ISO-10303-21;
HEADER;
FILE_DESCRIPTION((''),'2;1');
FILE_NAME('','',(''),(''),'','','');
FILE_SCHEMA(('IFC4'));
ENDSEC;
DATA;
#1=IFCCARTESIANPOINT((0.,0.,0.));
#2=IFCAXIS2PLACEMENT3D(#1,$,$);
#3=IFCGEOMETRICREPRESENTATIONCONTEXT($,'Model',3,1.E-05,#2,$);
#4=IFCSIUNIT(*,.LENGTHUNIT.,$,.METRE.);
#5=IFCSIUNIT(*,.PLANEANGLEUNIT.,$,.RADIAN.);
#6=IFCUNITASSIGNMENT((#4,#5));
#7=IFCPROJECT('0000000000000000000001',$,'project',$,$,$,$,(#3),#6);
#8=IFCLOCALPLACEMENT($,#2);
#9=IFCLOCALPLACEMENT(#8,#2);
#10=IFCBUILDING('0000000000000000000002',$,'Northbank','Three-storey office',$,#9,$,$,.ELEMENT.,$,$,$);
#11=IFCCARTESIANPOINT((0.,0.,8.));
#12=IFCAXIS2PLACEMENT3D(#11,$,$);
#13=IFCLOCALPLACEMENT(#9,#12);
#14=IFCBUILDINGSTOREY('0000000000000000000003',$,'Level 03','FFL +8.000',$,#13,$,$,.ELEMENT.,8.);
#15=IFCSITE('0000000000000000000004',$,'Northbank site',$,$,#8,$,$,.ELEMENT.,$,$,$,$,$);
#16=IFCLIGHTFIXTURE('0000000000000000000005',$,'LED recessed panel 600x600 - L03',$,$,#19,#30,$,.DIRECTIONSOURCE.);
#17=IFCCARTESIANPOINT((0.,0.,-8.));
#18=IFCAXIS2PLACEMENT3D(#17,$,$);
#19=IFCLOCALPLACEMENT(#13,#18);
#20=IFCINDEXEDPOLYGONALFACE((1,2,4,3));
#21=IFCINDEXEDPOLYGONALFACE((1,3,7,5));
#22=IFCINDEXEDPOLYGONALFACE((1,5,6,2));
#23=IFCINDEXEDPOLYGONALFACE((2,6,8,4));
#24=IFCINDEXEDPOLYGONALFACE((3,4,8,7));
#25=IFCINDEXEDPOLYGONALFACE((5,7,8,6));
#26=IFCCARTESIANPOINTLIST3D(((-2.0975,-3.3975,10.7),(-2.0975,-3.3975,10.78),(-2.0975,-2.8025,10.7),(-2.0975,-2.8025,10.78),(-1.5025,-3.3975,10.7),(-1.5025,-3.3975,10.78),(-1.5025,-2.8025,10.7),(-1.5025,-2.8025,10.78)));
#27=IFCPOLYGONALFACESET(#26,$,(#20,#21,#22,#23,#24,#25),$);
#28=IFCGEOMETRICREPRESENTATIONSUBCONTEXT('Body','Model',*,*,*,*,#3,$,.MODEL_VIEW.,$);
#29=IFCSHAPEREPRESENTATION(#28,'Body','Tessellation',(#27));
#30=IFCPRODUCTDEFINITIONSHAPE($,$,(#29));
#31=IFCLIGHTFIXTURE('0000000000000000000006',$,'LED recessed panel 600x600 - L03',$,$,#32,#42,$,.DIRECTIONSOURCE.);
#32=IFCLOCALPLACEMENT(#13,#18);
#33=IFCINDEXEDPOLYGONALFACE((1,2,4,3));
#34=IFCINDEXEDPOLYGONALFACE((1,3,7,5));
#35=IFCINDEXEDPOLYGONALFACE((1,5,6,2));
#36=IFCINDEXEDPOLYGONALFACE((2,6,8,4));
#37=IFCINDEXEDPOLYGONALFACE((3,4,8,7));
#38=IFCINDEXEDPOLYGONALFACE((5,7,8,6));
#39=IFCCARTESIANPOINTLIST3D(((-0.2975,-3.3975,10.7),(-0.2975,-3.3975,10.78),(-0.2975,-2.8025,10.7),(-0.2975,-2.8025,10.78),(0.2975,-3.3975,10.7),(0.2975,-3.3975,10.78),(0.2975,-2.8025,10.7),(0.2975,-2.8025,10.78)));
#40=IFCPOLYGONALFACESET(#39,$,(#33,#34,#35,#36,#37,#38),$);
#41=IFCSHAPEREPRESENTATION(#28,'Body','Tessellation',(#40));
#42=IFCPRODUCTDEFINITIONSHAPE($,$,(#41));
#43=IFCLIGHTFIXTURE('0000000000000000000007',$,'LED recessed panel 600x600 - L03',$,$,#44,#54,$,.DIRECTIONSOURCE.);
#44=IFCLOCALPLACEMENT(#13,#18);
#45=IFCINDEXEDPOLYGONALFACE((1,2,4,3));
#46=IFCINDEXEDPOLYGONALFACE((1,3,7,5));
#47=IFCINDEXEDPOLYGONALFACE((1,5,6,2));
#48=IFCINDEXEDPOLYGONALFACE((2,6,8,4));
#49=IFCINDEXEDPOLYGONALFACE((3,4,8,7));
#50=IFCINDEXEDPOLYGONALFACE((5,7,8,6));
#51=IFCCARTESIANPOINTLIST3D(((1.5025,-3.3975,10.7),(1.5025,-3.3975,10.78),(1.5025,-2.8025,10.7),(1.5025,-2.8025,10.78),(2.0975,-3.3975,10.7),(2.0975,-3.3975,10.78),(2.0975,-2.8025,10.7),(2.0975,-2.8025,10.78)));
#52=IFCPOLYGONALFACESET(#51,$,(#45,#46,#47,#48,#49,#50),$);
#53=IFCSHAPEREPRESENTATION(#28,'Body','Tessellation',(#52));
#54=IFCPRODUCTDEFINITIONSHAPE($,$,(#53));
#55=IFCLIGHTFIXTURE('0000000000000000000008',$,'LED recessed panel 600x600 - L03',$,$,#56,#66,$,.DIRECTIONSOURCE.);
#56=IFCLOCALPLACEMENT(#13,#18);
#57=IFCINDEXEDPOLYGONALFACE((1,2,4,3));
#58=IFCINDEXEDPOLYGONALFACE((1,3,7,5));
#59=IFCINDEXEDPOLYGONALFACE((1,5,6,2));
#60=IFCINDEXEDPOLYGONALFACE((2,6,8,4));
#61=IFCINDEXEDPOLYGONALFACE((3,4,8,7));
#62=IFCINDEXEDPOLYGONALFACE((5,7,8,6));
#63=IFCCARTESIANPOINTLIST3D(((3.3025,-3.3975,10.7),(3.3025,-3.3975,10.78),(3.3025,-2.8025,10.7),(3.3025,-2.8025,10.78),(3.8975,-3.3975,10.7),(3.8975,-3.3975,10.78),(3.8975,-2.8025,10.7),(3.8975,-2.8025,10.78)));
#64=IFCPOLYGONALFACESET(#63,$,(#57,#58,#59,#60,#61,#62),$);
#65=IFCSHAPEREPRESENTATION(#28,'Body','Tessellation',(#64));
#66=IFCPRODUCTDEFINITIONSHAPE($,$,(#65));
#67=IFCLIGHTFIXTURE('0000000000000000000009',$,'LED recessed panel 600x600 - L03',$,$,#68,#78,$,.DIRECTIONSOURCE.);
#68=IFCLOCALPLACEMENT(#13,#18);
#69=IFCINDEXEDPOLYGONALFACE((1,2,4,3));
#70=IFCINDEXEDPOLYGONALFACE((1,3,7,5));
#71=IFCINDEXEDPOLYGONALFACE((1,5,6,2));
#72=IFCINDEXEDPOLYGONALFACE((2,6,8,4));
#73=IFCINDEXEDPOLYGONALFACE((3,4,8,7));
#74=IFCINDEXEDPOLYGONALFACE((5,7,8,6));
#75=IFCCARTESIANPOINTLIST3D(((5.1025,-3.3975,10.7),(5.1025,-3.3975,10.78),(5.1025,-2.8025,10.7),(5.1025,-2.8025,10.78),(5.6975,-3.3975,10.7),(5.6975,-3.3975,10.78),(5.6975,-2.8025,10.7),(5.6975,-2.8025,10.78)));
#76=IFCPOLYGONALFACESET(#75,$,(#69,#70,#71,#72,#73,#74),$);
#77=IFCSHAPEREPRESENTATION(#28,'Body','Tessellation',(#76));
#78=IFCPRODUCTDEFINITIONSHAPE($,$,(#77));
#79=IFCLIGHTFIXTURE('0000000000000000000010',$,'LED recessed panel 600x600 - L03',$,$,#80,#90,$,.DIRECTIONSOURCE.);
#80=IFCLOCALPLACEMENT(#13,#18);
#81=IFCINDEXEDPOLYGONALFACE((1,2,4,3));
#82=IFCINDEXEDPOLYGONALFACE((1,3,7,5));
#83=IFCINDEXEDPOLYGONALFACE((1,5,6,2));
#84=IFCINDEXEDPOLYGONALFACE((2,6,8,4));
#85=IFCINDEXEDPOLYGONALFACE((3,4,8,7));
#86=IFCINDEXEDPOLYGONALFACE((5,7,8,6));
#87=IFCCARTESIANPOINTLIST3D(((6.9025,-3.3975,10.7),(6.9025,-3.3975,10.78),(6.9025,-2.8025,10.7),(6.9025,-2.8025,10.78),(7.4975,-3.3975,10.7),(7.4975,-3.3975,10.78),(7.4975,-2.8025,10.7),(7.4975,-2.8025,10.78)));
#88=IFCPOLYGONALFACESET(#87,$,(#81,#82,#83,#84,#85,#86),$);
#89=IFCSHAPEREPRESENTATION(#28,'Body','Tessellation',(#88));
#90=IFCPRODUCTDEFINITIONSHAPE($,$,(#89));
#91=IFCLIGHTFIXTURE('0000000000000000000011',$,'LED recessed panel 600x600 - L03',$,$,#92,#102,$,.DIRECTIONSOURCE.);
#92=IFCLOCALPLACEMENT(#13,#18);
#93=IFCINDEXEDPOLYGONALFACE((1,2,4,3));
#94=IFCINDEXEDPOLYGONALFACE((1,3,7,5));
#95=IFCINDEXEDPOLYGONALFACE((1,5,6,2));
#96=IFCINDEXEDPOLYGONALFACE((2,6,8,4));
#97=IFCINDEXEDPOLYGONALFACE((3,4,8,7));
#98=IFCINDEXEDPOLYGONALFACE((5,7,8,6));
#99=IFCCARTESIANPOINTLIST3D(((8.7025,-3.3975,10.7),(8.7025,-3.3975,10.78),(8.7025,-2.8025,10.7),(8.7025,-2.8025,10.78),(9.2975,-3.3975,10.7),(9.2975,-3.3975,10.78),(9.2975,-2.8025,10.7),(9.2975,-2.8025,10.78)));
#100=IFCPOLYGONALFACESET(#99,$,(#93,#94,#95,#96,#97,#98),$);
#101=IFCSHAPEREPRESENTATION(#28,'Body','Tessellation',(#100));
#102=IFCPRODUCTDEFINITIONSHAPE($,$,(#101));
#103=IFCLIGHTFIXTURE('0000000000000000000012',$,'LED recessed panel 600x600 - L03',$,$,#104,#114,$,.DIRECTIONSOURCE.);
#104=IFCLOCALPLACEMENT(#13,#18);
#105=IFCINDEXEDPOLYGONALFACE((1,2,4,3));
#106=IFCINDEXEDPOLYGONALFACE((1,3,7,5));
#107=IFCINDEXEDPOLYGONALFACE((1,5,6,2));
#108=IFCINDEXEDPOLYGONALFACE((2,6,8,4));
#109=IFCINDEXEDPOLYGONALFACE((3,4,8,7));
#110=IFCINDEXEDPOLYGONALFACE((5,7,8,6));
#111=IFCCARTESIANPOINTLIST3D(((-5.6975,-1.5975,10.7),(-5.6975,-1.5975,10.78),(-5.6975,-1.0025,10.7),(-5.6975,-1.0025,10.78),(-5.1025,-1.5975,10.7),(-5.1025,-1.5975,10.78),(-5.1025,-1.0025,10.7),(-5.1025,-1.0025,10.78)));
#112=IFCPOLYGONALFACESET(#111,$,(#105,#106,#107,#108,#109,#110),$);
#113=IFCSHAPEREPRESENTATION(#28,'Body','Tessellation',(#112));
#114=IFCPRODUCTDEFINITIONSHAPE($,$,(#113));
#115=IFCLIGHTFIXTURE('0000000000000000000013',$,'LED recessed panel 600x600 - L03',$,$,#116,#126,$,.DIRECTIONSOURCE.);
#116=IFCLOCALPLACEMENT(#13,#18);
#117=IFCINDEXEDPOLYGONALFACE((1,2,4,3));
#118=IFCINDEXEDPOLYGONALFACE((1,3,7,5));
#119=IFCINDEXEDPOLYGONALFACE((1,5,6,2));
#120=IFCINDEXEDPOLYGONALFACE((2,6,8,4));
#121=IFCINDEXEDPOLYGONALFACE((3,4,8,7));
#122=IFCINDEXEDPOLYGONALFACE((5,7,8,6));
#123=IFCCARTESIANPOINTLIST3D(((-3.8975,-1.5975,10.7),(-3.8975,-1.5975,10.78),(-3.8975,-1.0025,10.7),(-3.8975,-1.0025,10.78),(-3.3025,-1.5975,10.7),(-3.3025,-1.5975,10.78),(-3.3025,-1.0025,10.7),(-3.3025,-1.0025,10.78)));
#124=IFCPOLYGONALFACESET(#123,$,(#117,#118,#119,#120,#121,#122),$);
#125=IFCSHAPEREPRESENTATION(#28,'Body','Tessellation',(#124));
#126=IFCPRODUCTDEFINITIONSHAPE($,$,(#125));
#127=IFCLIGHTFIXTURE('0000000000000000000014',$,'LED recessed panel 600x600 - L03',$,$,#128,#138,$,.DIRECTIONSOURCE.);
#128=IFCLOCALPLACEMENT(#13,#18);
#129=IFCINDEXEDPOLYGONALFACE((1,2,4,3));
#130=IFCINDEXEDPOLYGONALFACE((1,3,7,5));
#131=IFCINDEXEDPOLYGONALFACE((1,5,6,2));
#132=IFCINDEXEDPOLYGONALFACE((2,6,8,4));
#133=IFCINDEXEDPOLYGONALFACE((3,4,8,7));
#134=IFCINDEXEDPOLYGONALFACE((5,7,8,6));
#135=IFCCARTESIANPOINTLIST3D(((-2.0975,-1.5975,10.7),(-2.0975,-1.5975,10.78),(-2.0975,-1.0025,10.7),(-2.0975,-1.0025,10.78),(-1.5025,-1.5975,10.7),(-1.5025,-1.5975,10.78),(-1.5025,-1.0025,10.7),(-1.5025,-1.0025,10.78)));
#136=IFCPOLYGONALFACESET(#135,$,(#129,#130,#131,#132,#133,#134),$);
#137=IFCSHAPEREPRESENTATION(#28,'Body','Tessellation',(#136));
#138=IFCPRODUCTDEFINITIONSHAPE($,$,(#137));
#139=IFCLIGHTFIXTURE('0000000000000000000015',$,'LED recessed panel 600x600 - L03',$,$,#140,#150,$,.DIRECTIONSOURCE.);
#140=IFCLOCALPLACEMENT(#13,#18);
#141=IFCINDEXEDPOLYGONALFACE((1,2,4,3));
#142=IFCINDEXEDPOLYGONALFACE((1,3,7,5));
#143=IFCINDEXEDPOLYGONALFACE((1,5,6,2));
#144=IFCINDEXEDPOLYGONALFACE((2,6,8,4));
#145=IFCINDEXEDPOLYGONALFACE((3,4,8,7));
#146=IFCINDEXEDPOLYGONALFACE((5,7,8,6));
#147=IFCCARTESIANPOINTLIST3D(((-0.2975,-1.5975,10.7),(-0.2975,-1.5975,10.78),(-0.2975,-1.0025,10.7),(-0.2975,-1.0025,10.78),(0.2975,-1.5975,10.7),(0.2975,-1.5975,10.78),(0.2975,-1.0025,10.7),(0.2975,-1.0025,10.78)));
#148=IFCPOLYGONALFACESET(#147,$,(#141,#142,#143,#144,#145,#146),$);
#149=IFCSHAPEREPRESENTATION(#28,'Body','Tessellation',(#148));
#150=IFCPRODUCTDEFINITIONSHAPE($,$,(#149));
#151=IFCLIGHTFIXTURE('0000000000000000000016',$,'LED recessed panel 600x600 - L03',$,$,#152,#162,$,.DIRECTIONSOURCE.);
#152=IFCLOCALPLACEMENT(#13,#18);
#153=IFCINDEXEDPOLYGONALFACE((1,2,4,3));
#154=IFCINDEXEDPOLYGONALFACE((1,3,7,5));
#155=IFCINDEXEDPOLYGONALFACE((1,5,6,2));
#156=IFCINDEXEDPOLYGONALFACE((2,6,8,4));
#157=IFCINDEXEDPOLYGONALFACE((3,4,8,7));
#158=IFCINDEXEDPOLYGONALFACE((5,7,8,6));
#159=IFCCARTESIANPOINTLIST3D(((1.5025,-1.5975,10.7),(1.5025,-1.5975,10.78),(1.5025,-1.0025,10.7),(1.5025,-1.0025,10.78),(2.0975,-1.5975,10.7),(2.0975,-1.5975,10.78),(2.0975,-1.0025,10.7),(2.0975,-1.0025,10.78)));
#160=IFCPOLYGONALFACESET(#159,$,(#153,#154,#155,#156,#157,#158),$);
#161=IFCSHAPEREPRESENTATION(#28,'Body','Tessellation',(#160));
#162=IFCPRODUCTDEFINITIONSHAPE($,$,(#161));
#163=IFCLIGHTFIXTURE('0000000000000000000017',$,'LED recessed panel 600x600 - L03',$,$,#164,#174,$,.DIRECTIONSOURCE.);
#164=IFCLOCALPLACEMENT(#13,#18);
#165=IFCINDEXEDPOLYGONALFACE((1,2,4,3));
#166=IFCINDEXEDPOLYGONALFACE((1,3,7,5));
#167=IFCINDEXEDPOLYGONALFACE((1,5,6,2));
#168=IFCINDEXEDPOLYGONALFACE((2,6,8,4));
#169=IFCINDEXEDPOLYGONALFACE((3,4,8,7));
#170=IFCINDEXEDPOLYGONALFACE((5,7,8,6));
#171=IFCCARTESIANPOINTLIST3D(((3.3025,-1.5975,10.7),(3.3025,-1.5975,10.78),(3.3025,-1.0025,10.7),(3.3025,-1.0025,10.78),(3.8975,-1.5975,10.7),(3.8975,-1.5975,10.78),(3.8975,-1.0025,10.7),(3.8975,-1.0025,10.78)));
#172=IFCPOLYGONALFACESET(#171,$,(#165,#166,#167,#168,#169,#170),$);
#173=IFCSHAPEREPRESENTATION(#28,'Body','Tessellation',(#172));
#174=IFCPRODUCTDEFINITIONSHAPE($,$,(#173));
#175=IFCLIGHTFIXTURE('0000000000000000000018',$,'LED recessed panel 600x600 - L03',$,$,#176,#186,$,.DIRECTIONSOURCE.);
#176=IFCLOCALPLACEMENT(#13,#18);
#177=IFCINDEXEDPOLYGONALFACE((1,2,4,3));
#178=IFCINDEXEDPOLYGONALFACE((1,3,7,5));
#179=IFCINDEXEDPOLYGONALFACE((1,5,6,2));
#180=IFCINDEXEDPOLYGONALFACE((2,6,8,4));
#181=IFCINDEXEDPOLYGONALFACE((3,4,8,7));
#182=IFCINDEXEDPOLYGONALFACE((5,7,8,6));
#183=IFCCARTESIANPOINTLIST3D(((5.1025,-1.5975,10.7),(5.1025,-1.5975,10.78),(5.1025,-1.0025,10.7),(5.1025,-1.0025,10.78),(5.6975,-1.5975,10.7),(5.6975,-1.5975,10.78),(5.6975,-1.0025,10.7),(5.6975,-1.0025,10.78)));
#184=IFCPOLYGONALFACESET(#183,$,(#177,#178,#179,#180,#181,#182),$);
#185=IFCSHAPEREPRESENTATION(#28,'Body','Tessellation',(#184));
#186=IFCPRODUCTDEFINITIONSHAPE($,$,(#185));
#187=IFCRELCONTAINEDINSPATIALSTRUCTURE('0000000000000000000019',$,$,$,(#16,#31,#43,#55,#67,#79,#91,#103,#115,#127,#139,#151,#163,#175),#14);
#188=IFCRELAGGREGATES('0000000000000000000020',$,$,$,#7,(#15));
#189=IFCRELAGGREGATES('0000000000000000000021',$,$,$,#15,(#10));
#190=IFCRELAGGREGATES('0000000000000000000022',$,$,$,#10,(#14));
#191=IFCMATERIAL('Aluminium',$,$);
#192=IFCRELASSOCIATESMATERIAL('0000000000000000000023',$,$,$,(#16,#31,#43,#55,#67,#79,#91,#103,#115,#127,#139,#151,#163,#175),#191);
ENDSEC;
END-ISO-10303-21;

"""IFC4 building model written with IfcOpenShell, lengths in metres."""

from ifc_helpers import new_model, si_unit, frame, origin, place, context, subcontext, project, spatial, rectangle, extrude, material, element, save


model = new_model("IFC4")

# Units and contexts
model_context = context("Model", 3, precision=1e-05, world=origin())
body_context = subcontext(model_context, "Body", "Model", "MODEL_VIEW")
ifc_project = project(units=[si_unit("LENGTHUNIT", "METRE"), si_unit("PLANEANGLEUNIT", "RADIAN")], contexts=[model_context])

# Site, building, storey
site_placement = place(None, origin())
site = spatial("IfcSite", under=ifc_project, at=site_placement, Name="Northbank site", CompositionType="ELEMENT")
building_placement = place(site_placement, origin())
building = spatial("IfcBuilding", under=site, at=building_placement, Name="Northbank", Description="Three-storey office", CompositionType="ELEMENT")
storey_placement = place(building_placement, frame((0.0, 0.0, 8.0)))
storey = spatial("IfcBuildingStorey", under=building, at=storey_placement, Name="Level 03", Description="FFL +8.000", CompositionType="ELEMENT", Elevation=8.0)

# Light fixtures
ifc_material = material(Name="Aluminium")
light_fixture_1_placement = place(storey_placement, frame((0.0, 0.0, -8.0)))
element("IfcLightFixture", 1, at=light_fixture_1_placement, inside=storey, material=ifc_material, Name="LED recessed panel 600x600 - L03", PredefinedType="DIRECTIONSOURCE", context=body_context, shape_type="SweptSolid", body=[
    extrude(rectangle(XDim=0.595, YDim=0.595), frame((-1.8, -3.1, 10.7)), (0.0, 0.0, 1.0), 0.08),
])
light_fixture_2_placement = place(storey_placement, frame((0.0, 0.0, -8.0)))
element("IfcLightFixture", 2, at=light_fixture_2_placement, inside=storey, material=ifc_material, Name="LED recessed panel 600x600 - L03", PredefinedType="DIRECTIONSOURCE", context=body_context, shape_type="SweptSolid", body=[
    extrude(rectangle(XDim=0.595, YDim=0.595), frame((0.0, -3.1, 10.7)), (0.0, 0.0, 1.0), 0.08),
])
light_fixture_3_placement = place(storey_placement, frame((0.0, 0.0, -8.0)))
element("IfcLightFixture", 3, at=light_fixture_3_placement, inside=storey, material=ifc_material, Name="LED recessed panel 600x600 - L03", PredefinedType="DIRECTIONSOURCE", context=body_context, shape_type="SweptSolid", body=[
    extrude(rectangle(XDim=0.595, YDim=0.595), frame((1.8, -3.1, 10.7)), (0.0, 0.0, 1.0), 0.08),
])
light_fixture_4_placement = place(storey_placement, frame((0.0, 0.0, -8.0)))
element("IfcLightFixture", 4, at=light_fixture_4_placement, inside=storey, material=ifc_material, Name="LED recessed panel 600x600 - L03", PredefinedType="DIRECTIONSOURCE", context=body_context, shape_type="SweptSolid", body=[
    extrude(rectangle(XDim=0.595, YDim=0.595), frame((3.6, -3.1, 10.7)), (0.0, 0.0, 1.0), 0.08),
])
light_fixture_5_placement = place(storey_placement, frame((0.0, 0.0, -8.0)))
element("IfcLightFixture", 5, at=light_fixture_5_placement, inside=storey, material=ifc_material, Name="LED recessed panel 600x600 - L03", PredefinedType="DIRECTIONSOURCE", context=body_context, shape_type="SweptSolid", body=[
    extrude(rectangle(XDim=0.595, YDim=0.595), frame((5.4, -3.1, 10.7)), (0.0, 0.0, 1.0), 0.08),
])
light_fixture_6_placement = place(storey_placement, frame((0.0, 0.0, -8.0)))
element("IfcLightFixture", 6, at=light_fixture_6_placement, inside=storey, material=ifc_material, Name="LED recessed panel 600x600 - L03", PredefinedType="DIRECTIONSOURCE", context=body_context, shape_type="SweptSolid", body=[
    extrude(rectangle(XDim=0.595, YDim=0.595), frame((7.2, -3.1, 10.7)), (0.0, 0.0, 1.0), 0.08),
])
light_fixture_7_placement = place(storey_placement, frame((0.0, 0.0, -8.0)))
element("IfcLightFixture", 7, at=light_fixture_7_placement, inside=storey, material=ifc_material, Name="LED recessed panel 600x600 - L03", PredefinedType="DIRECTIONSOURCE", context=body_context, shape_type="SweptSolid", body=[
    extrude(rectangle(XDim=0.595, YDim=0.595), frame((9.0, -3.1, 10.7)), (0.0, 0.0, 1.0), 0.08),
])
light_fixture_8_placement = place(storey_placement, frame((0.0, 0.0, -8.0)))
element("IfcLightFixture", 8, at=light_fixture_8_placement, inside=storey, material=ifc_material, Name="LED recessed panel 600x600 - L03", PredefinedType="DIRECTIONSOURCE", context=body_context, shape_type="SweptSolid", body=[
    extrude(rectangle(XDim=0.595, YDim=0.595), frame((-5.4, -1.3, 10.7)), (0.0, 0.0, 1.0), 0.08),
])
light_fixture_9_placement = place(storey_placement, frame((0.0, 0.0, -8.0)))
element("IfcLightFixture", 9, at=light_fixture_9_placement, inside=storey, material=ifc_material, Name="LED recessed panel 600x600 - L03", PredefinedType="DIRECTIONSOURCE", context=body_context, shape_type="SweptSolid", body=[
    extrude(rectangle(XDim=0.595, YDim=0.595), frame((-3.6, -1.3, 10.7)), (0.0, 0.0, 1.0), 0.08),
])
light_fixture_10_placement = place(storey_placement, frame((0.0, 0.0, -8.0)))
element("IfcLightFixture", 10, at=light_fixture_10_placement, inside=storey, material=ifc_material, Name="LED recessed panel 600x600 - L03", PredefinedType="DIRECTIONSOURCE", context=body_context, shape_type="SweptSolid", body=[
    extrude(rectangle(XDim=0.595, YDim=0.595), frame((-1.8, -1.3, 10.7)), (0.0, 0.0, 1.0), 0.08),
])
light_fixture_11_placement = place(storey_placement, frame((0.0, 0.0, -8.0)))
element("IfcLightFixture", 11, at=light_fixture_11_placement, inside=storey, material=ifc_material, Name="LED recessed panel 600x600 - L03", PredefinedType="DIRECTIONSOURCE", context=body_context, shape_type="SweptSolid", body=[
    extrude(rectangle(XDim=0.595, YDim=0.595), frame((0.0, -1.3, 10.7)), (0.0, 0.0, 1.0), 0.08),
])
light_fixture_12_placement = place(storey_placement, frame((0.0, 0.0, -8.0)))
element("IfcLightFixture", 12, at=light_fixture_12_placement, inside=storey, material=ifc_material, Name="LED recessed panel 600x600 - L03", PredefinedType="DIRECTIONSOURCE", context=body_context, shape_type="SweptSolid", body=[
    extrude(rectangle(XDim=0.595, YDim=0.595), frame((1.8, -1.3, 10.7)), (0.0, 0.0, 1.0), 0.08),
])
light_fixture_13_placement = place(storey_placement, frame((0.0, 0.0, -8.0)))
element("IfcLightFixture", 13, at=light_fixture_13_placement, inside=storey, material=ifc_material, Name="LED recessed panel 600x600 - L03", PredefinedType="DIRECTIONSOURCE", context=body_context, shape_type="SweptSolid", body=[
    extrude(rectangle(XDim=0.595, YDim=0.595), frame((3.6, -1.3, 10.7)), (0.0, 0.0, 1.0), 0.08),
])
light_fixture_14_placement = place(storey_placement, frame((0.0, 0.0, -8.0)))
element("IfcLightFixture", 14, at=light_fixture_14_placement, inside=storey, material=ifc_material, Name="LED recessed panel 600x600 - L03", PredefinedType="DIRECTIONSOURCE", context=body_context, shape_type="SweptSolid", body=[
    extrude(rectangle(XDim=0.595, YDim=0.595), frame((5.4, -1.3, 10.7)), (0.0, 0.0, 1.0), 0.08),
])

save(model, "model.ifc")
